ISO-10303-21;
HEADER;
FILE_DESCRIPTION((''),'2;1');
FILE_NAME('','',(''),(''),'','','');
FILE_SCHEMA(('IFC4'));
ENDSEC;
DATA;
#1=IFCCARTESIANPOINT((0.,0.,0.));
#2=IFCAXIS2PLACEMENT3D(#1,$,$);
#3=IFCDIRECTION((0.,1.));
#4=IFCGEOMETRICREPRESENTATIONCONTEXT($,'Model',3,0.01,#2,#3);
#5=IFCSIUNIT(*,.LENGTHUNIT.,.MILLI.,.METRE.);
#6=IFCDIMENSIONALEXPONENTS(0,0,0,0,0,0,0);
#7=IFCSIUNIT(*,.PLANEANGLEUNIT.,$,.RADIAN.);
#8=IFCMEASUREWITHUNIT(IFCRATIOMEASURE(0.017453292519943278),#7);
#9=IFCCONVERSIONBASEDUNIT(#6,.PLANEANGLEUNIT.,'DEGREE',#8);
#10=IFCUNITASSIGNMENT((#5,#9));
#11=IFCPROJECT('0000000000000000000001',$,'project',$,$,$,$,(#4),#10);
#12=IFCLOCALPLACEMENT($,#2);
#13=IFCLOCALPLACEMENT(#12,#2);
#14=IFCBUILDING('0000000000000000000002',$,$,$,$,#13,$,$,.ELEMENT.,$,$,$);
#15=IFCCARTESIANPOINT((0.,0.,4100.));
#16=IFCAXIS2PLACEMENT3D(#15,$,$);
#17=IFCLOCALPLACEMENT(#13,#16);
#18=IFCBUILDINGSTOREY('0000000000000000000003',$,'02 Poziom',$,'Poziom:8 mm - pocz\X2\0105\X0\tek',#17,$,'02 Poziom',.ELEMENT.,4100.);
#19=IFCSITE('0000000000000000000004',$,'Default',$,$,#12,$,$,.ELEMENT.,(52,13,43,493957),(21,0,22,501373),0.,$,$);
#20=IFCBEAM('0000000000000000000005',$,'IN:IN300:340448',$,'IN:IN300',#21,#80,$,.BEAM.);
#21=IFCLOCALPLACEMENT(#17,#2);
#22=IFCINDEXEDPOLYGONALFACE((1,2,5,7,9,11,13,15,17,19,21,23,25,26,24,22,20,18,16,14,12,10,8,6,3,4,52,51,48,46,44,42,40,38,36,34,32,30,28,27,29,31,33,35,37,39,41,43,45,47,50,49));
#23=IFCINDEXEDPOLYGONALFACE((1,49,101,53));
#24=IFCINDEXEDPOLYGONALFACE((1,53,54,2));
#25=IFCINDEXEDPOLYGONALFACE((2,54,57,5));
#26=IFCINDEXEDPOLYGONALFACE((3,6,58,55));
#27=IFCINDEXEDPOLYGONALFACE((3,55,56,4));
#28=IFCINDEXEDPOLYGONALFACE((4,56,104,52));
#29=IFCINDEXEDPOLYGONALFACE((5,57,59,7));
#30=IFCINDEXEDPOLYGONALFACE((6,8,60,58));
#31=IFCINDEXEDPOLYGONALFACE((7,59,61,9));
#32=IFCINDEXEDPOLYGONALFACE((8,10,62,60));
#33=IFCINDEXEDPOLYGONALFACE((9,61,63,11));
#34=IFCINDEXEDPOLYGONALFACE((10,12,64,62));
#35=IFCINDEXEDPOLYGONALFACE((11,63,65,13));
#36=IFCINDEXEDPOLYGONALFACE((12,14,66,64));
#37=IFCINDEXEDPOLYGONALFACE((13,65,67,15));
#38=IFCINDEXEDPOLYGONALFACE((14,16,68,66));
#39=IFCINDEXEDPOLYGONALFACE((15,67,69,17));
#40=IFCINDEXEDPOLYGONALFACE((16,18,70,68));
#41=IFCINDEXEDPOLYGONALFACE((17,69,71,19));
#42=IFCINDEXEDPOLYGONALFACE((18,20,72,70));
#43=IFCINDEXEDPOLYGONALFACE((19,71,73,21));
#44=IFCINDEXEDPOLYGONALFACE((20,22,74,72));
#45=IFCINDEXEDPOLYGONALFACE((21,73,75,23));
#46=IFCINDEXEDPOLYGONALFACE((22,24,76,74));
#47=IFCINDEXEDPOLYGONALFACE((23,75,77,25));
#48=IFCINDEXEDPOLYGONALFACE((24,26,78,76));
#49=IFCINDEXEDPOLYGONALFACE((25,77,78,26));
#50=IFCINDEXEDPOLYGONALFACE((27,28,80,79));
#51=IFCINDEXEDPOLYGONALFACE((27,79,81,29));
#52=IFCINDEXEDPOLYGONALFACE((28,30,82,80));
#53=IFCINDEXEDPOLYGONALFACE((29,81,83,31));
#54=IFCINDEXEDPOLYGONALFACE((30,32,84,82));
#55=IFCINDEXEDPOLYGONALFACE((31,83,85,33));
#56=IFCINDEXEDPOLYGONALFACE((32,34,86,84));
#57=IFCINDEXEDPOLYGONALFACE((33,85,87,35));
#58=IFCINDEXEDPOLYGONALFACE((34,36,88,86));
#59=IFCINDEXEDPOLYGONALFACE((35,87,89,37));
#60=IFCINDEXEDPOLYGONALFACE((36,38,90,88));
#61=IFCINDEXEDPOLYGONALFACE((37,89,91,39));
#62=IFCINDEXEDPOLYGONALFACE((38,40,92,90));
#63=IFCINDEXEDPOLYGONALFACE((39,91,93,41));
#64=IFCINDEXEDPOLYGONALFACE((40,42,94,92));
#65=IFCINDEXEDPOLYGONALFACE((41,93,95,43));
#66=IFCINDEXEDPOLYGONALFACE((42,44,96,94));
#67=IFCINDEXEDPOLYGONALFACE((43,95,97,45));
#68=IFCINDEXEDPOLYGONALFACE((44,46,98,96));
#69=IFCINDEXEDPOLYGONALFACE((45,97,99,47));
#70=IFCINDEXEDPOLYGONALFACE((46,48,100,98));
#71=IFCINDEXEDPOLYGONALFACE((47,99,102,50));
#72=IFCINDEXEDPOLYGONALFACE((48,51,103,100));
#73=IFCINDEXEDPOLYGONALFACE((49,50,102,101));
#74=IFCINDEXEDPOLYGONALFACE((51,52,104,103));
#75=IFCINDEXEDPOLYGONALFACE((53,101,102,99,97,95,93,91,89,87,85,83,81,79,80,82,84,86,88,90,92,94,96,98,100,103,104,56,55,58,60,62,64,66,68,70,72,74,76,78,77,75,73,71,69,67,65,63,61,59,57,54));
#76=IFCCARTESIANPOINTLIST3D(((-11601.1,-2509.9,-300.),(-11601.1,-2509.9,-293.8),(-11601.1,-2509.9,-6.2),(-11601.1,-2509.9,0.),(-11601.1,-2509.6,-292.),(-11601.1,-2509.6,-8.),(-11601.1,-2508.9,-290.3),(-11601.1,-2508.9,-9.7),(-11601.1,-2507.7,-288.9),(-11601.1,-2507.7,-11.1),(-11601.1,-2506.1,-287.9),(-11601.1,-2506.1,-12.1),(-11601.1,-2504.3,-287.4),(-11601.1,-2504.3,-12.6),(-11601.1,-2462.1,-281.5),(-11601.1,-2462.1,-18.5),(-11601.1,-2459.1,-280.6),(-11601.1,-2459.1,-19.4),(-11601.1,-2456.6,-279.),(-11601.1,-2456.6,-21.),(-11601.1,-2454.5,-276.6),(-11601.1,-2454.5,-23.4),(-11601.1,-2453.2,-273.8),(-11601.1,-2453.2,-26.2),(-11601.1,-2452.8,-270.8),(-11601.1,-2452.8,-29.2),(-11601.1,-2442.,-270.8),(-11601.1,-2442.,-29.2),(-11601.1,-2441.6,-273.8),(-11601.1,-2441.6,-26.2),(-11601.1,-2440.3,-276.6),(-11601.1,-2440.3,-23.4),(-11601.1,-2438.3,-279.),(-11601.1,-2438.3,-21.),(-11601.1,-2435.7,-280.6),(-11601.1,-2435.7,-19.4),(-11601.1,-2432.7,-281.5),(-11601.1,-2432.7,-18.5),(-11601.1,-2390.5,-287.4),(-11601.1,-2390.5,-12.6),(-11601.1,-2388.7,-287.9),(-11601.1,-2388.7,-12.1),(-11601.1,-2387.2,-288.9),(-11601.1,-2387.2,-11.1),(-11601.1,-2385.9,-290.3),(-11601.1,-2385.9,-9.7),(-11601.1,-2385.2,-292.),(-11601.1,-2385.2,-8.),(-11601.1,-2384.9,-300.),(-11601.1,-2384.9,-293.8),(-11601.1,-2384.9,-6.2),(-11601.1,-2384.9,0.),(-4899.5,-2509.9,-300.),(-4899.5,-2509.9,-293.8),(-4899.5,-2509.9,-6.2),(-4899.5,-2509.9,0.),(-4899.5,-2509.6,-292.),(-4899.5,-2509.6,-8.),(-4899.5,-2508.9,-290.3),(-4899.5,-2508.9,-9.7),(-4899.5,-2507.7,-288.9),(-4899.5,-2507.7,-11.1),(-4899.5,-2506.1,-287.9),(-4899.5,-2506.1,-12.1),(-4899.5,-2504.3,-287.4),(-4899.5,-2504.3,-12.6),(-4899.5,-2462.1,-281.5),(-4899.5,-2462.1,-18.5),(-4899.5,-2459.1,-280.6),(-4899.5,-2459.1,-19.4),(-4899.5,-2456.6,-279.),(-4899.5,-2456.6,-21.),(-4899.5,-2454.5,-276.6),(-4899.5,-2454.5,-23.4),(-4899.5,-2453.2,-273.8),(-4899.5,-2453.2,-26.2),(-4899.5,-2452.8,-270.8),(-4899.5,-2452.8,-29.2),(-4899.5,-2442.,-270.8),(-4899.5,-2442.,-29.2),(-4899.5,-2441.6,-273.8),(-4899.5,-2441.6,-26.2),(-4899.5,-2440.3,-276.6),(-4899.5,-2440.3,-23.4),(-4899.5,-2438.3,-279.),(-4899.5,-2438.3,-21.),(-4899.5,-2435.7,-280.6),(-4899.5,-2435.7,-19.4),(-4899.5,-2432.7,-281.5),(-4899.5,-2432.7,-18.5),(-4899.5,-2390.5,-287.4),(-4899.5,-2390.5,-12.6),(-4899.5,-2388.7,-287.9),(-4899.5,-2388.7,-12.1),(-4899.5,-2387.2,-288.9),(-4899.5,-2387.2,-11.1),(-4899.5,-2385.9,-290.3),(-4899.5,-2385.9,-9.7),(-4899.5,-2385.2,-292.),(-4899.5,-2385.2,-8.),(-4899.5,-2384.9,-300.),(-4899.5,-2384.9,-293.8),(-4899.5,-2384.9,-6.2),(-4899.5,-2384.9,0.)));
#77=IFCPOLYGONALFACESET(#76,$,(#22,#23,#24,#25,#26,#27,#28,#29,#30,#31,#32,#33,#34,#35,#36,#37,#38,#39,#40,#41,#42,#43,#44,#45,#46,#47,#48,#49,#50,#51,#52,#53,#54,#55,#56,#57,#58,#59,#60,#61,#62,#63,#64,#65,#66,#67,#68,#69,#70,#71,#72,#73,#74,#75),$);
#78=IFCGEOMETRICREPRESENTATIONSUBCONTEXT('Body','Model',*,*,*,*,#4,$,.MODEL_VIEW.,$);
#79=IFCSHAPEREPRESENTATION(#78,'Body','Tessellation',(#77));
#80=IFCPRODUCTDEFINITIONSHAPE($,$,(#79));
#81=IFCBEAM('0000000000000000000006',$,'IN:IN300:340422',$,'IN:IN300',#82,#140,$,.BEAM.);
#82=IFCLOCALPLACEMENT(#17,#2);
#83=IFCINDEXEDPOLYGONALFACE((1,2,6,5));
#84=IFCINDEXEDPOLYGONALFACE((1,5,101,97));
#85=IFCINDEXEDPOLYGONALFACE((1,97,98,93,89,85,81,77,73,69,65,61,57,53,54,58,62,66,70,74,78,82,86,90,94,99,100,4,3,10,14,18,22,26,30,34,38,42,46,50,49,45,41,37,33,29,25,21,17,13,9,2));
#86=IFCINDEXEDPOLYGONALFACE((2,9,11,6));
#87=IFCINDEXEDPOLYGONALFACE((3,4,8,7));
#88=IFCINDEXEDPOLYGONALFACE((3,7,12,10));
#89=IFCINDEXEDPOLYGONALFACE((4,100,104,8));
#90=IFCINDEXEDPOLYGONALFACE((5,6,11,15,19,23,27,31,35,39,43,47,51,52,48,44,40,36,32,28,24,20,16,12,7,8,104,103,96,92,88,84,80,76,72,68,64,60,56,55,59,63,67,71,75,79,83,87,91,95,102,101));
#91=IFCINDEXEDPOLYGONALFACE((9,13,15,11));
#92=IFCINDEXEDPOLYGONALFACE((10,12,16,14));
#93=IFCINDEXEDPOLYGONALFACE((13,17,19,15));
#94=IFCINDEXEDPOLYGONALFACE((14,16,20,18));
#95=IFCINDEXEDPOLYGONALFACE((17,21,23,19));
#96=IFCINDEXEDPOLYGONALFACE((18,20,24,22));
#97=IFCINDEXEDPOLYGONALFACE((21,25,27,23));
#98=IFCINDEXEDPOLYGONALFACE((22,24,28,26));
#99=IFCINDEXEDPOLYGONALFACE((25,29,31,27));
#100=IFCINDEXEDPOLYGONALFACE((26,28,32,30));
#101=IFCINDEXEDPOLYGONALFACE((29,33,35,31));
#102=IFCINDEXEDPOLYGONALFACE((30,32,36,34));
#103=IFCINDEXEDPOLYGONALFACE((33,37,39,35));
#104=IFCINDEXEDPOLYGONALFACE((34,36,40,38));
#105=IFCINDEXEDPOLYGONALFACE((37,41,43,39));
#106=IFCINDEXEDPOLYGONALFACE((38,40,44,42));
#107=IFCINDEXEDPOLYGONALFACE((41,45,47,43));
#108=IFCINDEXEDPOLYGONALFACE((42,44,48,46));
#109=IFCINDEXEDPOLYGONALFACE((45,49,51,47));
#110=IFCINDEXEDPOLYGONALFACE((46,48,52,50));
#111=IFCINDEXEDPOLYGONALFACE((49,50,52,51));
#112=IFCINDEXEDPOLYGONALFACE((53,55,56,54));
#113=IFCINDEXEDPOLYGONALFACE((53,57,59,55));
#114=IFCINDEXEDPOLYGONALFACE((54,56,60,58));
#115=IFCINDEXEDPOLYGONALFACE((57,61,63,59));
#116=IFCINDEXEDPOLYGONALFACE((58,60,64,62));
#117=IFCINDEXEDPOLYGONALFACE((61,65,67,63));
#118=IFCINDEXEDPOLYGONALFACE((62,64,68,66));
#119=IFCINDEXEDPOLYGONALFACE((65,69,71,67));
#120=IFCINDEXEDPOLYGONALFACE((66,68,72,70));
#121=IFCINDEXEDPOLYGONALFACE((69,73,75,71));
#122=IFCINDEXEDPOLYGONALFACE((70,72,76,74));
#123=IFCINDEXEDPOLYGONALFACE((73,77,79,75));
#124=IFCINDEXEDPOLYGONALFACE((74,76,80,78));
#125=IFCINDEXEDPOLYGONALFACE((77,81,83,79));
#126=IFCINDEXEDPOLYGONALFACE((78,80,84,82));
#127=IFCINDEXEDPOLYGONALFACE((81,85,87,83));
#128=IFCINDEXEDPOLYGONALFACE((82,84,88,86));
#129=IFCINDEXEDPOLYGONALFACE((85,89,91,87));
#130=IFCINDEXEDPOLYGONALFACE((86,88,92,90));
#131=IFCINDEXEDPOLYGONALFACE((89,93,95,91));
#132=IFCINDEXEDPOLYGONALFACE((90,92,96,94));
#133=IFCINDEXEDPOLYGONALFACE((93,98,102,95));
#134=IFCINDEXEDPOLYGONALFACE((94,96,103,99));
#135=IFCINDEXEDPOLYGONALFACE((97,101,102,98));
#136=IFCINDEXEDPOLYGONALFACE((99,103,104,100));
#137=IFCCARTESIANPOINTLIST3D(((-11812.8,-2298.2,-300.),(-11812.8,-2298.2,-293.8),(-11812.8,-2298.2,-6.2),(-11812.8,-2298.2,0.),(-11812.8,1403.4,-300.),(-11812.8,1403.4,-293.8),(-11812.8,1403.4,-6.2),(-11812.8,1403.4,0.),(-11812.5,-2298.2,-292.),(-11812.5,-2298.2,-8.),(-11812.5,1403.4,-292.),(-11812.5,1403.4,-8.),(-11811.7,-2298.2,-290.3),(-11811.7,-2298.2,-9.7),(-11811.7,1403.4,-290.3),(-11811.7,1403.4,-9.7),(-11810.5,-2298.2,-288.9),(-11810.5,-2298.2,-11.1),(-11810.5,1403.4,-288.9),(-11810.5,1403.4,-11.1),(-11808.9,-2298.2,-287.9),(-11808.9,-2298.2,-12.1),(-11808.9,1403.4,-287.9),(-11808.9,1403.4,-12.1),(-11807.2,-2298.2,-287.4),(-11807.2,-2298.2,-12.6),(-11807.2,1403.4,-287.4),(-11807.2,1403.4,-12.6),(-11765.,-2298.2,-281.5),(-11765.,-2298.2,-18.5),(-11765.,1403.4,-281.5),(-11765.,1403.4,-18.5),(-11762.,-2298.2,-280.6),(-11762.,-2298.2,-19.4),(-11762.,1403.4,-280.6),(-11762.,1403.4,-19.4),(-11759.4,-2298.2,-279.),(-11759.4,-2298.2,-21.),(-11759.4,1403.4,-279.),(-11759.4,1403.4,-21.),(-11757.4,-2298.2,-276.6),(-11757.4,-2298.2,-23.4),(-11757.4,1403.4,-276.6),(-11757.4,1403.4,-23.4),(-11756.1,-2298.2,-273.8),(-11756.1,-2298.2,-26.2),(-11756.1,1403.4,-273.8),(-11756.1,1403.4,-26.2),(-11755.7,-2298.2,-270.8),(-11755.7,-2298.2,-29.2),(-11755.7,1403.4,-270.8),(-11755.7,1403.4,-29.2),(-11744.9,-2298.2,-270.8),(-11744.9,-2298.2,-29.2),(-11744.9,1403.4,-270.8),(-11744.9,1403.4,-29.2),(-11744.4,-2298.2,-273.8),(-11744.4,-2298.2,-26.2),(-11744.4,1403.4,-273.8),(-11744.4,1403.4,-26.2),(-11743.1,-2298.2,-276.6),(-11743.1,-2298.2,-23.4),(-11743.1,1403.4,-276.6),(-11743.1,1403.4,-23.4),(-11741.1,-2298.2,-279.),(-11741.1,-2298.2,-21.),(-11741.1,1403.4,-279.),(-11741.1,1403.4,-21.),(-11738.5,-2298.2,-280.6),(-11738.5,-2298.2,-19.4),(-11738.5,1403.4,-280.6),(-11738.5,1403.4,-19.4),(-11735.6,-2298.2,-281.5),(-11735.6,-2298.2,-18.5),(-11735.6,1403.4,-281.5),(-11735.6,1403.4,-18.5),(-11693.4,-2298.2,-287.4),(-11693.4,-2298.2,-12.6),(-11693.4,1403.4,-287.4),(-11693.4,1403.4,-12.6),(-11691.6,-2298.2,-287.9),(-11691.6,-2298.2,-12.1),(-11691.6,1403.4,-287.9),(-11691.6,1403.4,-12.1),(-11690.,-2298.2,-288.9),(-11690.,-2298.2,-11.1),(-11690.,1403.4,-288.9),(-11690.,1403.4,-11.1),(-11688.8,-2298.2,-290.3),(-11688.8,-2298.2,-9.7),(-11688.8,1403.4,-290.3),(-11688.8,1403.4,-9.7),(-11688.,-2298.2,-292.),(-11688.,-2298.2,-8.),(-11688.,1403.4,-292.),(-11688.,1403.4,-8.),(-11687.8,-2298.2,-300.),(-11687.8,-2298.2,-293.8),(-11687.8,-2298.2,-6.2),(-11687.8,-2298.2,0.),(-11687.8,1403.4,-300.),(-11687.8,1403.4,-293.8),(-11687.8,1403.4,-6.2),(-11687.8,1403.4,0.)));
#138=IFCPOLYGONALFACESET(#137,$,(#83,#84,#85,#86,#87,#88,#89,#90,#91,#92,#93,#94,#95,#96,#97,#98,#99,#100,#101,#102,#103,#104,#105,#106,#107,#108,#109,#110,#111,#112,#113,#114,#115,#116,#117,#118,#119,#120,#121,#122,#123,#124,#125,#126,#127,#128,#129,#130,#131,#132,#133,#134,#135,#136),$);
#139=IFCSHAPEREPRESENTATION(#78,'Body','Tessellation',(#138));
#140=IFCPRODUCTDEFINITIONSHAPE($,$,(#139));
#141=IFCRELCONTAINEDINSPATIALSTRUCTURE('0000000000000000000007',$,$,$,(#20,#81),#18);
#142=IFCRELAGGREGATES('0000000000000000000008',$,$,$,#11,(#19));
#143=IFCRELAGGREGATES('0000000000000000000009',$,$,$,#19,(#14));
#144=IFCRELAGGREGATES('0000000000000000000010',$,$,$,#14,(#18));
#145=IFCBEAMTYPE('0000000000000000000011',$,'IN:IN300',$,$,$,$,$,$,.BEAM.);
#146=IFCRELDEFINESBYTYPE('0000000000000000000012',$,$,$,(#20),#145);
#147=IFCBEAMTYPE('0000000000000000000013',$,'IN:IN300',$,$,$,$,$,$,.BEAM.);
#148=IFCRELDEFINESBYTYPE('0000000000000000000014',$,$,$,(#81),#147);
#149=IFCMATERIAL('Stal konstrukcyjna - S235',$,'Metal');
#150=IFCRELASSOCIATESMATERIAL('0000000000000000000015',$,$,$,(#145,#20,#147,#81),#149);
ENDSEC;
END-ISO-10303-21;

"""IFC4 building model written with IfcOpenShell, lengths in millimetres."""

from ifc_helpers import new_model, entity, si_unit, converted_unit, direction, frame, origin, place, context, subcontext, project, spatial, line, arc, indexed_curve, outline, extrude, source, transform, mapped, material, type_object, type_shapes, element, save


model = new_model("IFC4")

# Units and contexts
model_context = context("Model", 3, precision=0.01, world=origin(), true_north=direction((0.0, 1.0)))
body_context = subcontext(model_context, "Body", "Model", "MODEL_VIEW")
ifc_project = project(units=[si_unit("LENGTHUNIT", "METRE", prefix="MILLI"), converted_unit("PLANEANGLEUNIT", "DEGREE", entity("IfcRatioMeasure", 0.017453292519943278), si_unit("PLANEANGLEUNIT", "RADIAN"), dimensions=[0, 0, 0, 0, 0, 0, 0])], contexts=[model_context])

# Site, building, storey
site_placement = place(None, origin())
site = spatial("IfcSite", under=ifc_project, at=site_placement, Name="Default", CompositionType="ELEMENT", RefLatitude=(52, 13, 43, 493957), RefLongitude=(21, 0, 22, 501373), RefElevation=0.0)
building_placement = place(site_placement, origin())
building = spatial("IfcBuilding", under=site, at=building_placement, CompositionType="ELEMENT")
storey_placement = place(building_placement, frame((0.0, 0.0, 4100.0)))
storey = spatial("IfcBuildingStorey", under=building, at=storey_placement, Name="02 Poziom", ObjectType="Poziom:8 mm - początek", LongName="02 Poziom", CompositionType="ELEMENT", Elevation=4100.0)

# Shared definitions
ifc_material_1 = material(Name="Stal konstrukcyjna - S235", Category="Metal")

# Beams
beam_type_1 = type_object("IfcBeamType", Name="IN:IN300", PredefinedType="BEAM", material=ifc_material_1)
shared_shape_1 = source(origin(), body_context, "Body", "SweptSolid", [
    extrude(outline(indexed_curve([(143.8, -62.5), (150.0, -62.5), (150.0, 62.5), (143.8, 62.5), (139.6, 60.9), (137.4, 56.9), (131.5, 14.7), (127.9, 8.1), (120.8, 5.4), (-120.8, 5.4), (-127.9, 8.1), (-131.5, 14.7), (-137.4, 56.9), (-139.6, 60.9), (-143.8, 62.5), (-150.0, 62.5), (-150.0, -62.5), (-143.8, -62.5), (-139.6, -60.9), (-137.4, -56.9), (-131.5, -14.7), (-127.9, -8.1), (-120.8, -5.4), (120.8, -5.4), (127.9, -8.1), (131.5, -14.7), (137.4, -56.9), (139.6, -60.9)], segments=[line(1, 2, 3, 4), arc(4, 5, 6), line(6, 7), arc(7, 8, 9), line(9, 10), arc(10, 11, 12), line(12, 13), arc(13, 14, 15), line(15, 16, 17, 18), arc(18, 19, 20), line(20, 21), arc(21, 22, 23), line(23, 24), arc(24, 25, 26), line(26, 27), arc(27, 28, 1)], self_intersect=False)), frame((-3350.8, 0.0, 0.0), z_axis=(1.0, 0.0, 0.0), x_axis=(0.0, 0.0, -1.0)), (0.0, 0.0, 1.0), 6701.6),
])
type_shapes(beam_type_1, [shared_shape_1])
for number, where, name in (
    (1, (-8250.3, -2447.4, -150.0), "IN:IN300:340448"),
):
    element("IfcBeam", number, at=place(storey_placement, frame(where)), inside=storey, type_object=beam_type_1, material=ifc_material_1, Name=name, ObjectType="IN:IN300", PredefinedType="BEAM", context=body_context, shape_type="MappedRepresentation", body=[
        mapped(shared_shape_1, transform((0.0, 0.0, 0.0), scale=1.0)),
    ])
beam_type_2 = type_object("IfcBeamType", Name="IN:IN300", PredefinedType="BEAM", material=ifc_material_1)
shared_shape_2 = source(origin(), body_context, "Body", "SweptSolid", [
    extrude(outline(indexed_curve([(143.8, -62.5), (150.0, -62.5), (150.0, 62.5), (143.8, 62.5), (139.6, 60.9), (137.4, 56.9), (131.5, 14.7), (127.9, 8.1), (120.8, 5.4), (-120.8, 5.4), (-127.9, 8.1), (-131.5, 14.7), (-137.4, 56.9), (-139.6, 60.9), (-143.8, 62.5), (-150.0, 62.5), (-150.0, -62.5), (-143.8, -62.5), (-139.6, -60.9), (-137.4, -56.9), (-131.5, -14.7), (-127.9, -8.1), (-120.8, -5.4), (120.8, -5.4), (127.9, -8.1), (131.5, -14.7), (137.4, -56.9), (139.6, -60.9)], segments=[line(1, 2, 3, 4), arc(4, 5, 6), line(6, 7), arc(7, 8, 9), line(9, 10), arc(10, 11, 12), line(12, 13), arc(13, 14, 15), line(15, 16, 17, 18), arc(18, 19, 20), line(20, 21), arc(21, 22, 23), line(23, 24), arc(24, 25, 26), line(26, 27), arc(27, 28, 1)], self_intersect=False)), frame((-1850.8, 0.0, 0.0), z_axis=(1.0, 0.0, 0.0), x_axis=(0.0, 0.0, -1.0)), (0.0, 0.0, 1.0), 3701.6),
])
type_shapes(beam_type_2, [shared_shape_2])
for number, where, z_axis, x_axis, name in (
    (2, (-11750.3, -447.4, -150.0), (0.0, 0.0, 1.0), (0.0, -1.0, 0.0), "IN:IN300:340422"),
):
    element("IfcBeam", number, at=place(storey_placement, frame(where, z_axis=z_axis, x_axis=x_axis)), inside=storey, type_object=beam_type_2, material=ifc_material_1, Name=name, ObjectType="IN:IN300", PredefinedType="BEAM", context=body_context, shape_type="MappedRepresentation", body=[
        mapped(shared_shape_2, transform((0.0, 0.0, 0.0), scale=1.0)),
    ])

save(model, "model.ifc")
